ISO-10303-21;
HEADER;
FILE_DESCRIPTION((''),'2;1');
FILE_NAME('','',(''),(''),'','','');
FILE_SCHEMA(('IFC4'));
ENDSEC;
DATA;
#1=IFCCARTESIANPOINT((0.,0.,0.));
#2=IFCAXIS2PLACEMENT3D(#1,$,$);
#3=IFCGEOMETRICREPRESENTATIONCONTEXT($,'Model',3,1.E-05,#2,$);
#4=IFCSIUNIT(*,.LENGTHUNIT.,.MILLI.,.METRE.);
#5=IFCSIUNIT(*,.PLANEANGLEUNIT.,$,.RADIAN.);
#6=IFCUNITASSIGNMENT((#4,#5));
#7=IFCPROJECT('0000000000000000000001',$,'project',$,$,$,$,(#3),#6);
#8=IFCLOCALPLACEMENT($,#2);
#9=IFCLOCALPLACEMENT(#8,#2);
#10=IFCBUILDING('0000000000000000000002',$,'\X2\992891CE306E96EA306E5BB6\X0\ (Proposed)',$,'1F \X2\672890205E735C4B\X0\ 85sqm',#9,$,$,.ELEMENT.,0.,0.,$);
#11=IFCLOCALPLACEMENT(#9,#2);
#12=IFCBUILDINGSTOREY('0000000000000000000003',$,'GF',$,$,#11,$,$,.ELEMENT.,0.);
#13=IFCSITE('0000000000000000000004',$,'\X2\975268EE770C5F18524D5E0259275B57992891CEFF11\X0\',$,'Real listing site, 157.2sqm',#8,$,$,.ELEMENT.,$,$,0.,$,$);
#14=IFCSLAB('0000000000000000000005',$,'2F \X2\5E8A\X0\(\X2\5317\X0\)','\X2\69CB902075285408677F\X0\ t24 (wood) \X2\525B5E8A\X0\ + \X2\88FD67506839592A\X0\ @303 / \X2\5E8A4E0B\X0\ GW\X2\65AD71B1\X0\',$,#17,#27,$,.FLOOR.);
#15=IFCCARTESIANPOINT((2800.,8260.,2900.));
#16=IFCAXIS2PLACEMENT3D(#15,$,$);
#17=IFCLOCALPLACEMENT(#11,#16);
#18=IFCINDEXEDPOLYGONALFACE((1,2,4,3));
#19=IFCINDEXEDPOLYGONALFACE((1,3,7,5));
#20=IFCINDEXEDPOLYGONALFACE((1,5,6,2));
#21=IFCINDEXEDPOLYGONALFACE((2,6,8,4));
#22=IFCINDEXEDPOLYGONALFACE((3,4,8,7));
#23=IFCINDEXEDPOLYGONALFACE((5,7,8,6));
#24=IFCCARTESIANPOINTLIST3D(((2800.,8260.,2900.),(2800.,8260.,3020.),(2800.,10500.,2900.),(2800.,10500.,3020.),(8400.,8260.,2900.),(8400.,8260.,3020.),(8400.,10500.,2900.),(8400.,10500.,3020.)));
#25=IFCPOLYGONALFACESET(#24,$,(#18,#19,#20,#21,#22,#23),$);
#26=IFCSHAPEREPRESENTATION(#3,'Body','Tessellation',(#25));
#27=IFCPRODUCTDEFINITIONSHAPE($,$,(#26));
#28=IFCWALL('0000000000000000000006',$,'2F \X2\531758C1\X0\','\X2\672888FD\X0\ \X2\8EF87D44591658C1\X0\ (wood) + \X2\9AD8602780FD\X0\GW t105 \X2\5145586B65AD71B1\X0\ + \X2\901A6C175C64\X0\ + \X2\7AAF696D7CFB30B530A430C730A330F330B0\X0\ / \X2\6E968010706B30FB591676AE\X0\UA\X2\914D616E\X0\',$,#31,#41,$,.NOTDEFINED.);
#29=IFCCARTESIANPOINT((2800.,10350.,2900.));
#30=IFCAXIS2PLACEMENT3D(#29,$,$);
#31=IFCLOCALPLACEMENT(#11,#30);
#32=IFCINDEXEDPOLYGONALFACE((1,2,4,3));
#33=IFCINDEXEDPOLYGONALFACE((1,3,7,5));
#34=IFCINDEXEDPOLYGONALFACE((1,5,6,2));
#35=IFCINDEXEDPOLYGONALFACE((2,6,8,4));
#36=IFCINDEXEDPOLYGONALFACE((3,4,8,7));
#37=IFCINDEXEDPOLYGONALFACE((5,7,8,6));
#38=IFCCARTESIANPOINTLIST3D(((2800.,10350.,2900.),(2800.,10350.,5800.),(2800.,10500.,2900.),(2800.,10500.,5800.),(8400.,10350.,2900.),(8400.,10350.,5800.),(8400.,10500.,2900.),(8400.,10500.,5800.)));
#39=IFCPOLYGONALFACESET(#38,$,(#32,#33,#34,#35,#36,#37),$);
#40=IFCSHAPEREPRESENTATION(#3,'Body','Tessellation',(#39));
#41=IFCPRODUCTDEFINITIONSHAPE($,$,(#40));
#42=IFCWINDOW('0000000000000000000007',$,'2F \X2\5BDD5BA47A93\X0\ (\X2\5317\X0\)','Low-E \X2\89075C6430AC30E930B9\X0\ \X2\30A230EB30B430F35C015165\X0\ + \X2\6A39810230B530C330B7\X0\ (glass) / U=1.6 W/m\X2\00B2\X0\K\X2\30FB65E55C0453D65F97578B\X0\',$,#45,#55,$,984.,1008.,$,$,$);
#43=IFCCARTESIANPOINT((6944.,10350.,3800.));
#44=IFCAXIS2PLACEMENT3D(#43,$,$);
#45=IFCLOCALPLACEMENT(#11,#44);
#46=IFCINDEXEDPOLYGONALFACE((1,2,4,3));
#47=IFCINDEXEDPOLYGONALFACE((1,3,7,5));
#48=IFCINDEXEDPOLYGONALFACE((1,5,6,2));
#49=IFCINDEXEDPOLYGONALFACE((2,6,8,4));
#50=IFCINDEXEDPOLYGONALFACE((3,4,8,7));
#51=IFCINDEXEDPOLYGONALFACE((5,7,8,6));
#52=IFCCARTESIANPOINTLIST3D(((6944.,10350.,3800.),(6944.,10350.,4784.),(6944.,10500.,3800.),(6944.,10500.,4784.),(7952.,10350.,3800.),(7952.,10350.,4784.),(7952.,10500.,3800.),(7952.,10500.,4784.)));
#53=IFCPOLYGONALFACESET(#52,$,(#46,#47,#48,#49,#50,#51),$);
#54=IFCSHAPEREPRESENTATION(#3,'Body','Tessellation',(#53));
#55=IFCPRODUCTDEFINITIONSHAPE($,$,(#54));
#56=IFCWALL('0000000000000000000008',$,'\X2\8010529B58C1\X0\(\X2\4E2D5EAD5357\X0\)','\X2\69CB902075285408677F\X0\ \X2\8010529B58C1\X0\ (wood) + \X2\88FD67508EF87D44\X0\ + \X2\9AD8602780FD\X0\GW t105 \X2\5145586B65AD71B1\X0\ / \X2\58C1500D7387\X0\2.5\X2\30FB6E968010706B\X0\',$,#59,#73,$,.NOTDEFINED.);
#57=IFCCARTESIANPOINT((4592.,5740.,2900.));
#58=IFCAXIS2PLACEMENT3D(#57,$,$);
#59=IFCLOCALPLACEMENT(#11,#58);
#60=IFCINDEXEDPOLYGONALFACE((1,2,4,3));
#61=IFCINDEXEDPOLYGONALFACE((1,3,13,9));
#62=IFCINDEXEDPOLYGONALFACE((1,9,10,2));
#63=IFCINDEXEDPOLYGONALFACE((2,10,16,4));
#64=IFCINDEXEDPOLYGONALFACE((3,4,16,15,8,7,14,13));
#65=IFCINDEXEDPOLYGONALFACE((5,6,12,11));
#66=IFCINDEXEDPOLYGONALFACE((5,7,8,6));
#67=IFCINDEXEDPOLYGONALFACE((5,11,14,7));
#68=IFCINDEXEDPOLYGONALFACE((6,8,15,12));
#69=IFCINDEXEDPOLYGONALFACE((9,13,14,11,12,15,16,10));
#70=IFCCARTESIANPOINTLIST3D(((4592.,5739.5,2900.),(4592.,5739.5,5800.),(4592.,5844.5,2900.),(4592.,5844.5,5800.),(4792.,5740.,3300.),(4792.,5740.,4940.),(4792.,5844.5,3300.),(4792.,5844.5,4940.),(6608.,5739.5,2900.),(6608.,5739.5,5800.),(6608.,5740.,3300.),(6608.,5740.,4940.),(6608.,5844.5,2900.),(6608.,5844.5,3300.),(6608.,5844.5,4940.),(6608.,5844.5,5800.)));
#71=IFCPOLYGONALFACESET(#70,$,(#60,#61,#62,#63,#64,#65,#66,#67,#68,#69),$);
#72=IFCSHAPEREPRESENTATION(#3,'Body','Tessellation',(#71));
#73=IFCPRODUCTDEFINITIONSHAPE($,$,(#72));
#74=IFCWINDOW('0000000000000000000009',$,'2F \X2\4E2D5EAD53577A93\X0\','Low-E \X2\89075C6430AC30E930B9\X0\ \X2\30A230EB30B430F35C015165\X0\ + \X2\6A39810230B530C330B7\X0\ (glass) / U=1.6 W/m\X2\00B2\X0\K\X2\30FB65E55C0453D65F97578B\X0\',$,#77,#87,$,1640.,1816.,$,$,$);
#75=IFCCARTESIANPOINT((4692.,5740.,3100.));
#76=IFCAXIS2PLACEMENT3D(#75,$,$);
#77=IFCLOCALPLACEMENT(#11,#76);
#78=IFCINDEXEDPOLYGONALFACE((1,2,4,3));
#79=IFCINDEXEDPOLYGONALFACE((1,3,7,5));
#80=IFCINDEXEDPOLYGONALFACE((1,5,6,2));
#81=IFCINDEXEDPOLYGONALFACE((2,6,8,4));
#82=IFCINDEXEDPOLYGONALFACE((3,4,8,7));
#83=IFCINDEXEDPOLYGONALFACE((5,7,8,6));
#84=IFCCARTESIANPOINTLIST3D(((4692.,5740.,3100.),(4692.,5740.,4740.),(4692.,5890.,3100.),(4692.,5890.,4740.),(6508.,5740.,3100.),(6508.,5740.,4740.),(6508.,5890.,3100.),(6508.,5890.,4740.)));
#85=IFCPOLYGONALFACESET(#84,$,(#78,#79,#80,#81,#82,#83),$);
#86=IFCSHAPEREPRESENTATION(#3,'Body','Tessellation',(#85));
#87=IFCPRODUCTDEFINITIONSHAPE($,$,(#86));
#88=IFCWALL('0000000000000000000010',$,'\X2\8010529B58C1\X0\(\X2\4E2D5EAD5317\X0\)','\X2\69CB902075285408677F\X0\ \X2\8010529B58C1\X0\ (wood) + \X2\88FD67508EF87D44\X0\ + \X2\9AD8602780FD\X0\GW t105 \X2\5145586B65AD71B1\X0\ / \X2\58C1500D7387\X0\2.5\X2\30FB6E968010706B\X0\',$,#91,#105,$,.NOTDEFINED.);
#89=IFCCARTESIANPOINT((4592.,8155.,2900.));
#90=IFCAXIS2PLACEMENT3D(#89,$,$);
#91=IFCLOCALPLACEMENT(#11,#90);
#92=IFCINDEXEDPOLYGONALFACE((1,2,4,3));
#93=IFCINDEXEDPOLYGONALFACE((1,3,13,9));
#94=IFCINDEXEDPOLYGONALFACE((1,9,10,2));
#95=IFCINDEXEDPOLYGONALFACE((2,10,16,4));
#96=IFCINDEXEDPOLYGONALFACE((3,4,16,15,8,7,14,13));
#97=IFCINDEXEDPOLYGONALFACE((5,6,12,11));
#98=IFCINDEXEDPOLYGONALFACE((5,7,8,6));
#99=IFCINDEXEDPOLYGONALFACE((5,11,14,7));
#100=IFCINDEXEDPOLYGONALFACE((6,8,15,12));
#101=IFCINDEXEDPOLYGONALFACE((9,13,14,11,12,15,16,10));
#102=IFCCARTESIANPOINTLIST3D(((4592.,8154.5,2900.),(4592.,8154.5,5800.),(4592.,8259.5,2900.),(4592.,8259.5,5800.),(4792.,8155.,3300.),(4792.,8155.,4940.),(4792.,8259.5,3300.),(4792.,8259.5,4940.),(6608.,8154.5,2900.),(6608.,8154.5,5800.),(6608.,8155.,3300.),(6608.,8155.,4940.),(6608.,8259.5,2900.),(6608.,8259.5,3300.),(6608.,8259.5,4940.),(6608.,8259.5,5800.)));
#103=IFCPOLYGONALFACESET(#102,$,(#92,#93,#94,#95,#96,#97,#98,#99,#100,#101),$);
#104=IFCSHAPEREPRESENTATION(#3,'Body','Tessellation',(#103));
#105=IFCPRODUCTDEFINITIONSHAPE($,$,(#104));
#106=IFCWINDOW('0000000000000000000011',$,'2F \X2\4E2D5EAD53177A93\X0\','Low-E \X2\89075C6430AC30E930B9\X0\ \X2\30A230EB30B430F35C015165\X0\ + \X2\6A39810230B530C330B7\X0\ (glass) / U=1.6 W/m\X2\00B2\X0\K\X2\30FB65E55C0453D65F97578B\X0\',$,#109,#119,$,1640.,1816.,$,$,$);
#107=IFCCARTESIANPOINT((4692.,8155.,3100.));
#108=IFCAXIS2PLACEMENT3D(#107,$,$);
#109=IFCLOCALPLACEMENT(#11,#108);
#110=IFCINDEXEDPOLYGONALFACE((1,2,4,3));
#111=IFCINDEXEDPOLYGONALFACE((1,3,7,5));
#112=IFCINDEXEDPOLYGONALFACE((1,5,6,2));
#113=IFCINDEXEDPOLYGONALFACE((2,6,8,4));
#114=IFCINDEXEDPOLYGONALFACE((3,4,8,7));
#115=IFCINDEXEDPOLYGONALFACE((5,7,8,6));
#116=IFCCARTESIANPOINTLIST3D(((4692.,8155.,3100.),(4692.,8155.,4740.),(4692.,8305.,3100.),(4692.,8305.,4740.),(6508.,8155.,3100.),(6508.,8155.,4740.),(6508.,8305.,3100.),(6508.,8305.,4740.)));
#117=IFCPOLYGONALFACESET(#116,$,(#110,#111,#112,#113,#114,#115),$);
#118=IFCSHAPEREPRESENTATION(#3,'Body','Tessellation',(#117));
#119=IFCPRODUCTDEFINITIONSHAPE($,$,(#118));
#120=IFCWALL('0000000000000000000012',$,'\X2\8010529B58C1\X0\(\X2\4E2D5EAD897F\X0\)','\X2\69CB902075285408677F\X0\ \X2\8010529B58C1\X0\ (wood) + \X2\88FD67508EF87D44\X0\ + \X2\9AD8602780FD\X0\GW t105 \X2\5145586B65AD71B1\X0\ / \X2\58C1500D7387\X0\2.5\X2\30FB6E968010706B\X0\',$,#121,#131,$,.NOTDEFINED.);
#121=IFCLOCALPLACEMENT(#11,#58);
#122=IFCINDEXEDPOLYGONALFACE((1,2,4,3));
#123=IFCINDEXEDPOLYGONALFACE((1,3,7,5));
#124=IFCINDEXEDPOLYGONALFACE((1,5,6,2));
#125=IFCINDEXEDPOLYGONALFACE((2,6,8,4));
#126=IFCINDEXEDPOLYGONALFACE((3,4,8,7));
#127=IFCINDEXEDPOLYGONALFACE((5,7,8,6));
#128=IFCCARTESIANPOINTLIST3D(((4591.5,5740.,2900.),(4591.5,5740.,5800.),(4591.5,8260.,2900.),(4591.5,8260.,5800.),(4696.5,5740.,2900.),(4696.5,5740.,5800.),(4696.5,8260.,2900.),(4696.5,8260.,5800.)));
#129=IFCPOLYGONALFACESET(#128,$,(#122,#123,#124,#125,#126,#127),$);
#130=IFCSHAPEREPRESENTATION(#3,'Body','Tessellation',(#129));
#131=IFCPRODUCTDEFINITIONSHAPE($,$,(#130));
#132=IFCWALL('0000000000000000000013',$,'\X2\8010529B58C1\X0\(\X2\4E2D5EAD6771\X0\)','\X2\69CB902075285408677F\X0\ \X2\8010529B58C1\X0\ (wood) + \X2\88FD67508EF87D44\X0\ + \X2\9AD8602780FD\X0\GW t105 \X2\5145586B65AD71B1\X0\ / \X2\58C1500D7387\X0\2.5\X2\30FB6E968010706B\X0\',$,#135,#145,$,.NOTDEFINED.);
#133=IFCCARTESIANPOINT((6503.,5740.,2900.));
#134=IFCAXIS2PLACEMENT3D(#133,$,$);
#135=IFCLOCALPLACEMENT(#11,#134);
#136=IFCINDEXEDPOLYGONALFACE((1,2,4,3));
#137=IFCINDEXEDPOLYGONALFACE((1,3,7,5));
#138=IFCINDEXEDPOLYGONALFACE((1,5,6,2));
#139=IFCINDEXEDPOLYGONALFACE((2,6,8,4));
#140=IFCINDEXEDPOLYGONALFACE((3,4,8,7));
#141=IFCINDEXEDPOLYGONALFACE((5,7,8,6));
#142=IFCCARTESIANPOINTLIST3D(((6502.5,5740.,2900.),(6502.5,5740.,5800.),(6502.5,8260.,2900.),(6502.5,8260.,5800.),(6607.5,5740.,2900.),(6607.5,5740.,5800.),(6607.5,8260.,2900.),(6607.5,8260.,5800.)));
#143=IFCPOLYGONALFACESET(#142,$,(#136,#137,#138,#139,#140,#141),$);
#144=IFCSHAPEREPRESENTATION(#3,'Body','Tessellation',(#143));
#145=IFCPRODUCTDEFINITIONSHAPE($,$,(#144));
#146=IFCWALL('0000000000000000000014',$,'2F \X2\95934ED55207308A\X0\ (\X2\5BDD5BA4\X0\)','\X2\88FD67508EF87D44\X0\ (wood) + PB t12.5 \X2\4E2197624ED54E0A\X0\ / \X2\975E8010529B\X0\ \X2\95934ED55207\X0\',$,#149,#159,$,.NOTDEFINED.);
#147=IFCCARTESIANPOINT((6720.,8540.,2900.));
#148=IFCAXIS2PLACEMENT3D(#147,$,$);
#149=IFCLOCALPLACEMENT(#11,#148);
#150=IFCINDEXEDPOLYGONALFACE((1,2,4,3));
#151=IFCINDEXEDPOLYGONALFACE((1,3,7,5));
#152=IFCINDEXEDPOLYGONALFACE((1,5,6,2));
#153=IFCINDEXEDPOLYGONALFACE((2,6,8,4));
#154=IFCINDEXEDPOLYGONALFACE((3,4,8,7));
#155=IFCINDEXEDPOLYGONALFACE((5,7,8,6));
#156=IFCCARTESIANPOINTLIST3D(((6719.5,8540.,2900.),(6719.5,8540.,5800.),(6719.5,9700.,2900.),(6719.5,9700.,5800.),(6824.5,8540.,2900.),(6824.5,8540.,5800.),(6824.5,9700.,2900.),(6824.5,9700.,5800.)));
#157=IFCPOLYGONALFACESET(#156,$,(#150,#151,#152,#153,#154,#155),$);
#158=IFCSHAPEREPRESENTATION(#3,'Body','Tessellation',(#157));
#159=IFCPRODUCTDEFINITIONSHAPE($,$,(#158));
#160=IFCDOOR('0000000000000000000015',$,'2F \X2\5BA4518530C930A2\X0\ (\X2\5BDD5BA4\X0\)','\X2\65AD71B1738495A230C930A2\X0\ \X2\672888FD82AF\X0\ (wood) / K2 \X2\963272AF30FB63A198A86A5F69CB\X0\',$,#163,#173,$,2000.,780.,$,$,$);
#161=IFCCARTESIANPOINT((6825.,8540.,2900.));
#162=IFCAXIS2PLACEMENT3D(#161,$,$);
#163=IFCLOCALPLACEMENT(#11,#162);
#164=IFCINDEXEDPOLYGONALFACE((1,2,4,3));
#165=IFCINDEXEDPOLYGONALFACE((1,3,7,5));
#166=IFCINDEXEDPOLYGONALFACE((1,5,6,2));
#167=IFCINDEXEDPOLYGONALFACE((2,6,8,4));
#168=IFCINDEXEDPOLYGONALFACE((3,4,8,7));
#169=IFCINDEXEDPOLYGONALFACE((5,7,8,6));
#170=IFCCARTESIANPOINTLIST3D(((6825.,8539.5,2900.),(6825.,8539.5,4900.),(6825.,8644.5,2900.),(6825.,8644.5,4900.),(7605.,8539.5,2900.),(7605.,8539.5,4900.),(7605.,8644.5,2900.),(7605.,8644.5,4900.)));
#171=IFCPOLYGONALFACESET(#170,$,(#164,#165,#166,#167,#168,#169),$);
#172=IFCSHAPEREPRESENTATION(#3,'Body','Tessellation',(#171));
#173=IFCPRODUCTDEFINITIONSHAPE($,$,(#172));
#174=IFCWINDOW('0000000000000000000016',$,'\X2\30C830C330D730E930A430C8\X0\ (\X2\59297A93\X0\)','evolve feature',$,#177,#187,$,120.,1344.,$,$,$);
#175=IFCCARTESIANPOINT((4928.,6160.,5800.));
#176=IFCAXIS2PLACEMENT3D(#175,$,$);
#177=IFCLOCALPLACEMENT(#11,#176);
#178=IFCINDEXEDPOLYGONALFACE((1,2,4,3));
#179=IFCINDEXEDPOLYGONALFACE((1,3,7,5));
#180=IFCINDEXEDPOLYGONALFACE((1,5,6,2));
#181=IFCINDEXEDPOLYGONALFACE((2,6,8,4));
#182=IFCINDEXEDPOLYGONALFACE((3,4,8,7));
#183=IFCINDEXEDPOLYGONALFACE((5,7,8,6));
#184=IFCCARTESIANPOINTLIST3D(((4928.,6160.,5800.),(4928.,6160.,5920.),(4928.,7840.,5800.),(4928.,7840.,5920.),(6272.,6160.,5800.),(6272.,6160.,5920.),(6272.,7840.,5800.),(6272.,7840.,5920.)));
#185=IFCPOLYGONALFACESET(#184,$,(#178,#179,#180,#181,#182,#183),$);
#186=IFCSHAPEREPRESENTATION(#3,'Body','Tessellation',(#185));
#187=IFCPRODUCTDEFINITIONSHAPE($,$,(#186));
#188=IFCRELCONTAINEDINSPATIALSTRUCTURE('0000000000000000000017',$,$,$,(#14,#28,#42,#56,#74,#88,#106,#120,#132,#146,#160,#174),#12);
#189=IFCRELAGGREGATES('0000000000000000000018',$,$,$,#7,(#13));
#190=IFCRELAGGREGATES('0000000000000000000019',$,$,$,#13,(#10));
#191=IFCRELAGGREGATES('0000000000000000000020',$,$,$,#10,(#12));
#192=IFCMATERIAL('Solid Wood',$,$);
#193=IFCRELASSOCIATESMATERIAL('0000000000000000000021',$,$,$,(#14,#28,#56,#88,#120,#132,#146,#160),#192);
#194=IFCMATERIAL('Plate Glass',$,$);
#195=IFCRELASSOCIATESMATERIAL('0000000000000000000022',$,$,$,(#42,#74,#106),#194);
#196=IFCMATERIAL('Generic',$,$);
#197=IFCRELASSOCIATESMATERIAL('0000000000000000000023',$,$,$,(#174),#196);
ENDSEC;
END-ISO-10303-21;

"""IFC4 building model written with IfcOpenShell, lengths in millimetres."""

from ifc_helpers import new_model, si_unit, frame, frame_2d, origin, place, context, project, spatial, rectangle, extrude, material, element, fill, save


model = new_model("IFC4")

# Units and contexts
model_context = context("Model", 3, precision=1e-05, world=origin())
ifc_project = project(units=[si_unit("LENGTHUNIT", "METRE", prefix="MILLI"), si_unit("PLANEANGLEUNIT", "RADIAN")], contexts=[model_context])

# Site, building, storey
site_placement = place(None, origin())
site = spatial("IfcSite", under=ifc_project, at=site_placement, Name="青森県弘前市大字館野１", ObjectType="Real listing site, 157.2sqm", CompositionType="ELEMENT", RefElevation=0.0)
building_placement = place(site_placement, origin())
building = spatial("IfcBuilding", under=site, at=building_placement, Name="館野の雪の家 (Proposed)", ObjectType="1F 木造平屋 85sqm", CompositionType="ELEMENT", ElevationOfRefHeight=0.0, ElevationOfTerrain=0.0)
storey_placement = place(building_placement, origin())
storey = spatial("IfcBuildingStorey", under=building, at=storey_placement, Name="GF", CompositionType="ELEMENT", Elevation=0.0)

# Slab
ifc_material_1 = material(Name="Solid Wood")
slab_placement = place(storey_placement, frame((2800.0, 8260.0, 2900.0)))
element("IfcSlab", 1, at=slab_placement, inside=storey, material=ifc_material_1, Name="2F 床(北)", Description="構造用合板 t24 (wood) 剛床 + 製材根太 @303 / 床下 GW断熱", PredefinedType="FLOOR", context=model_context, shape_type="SweptSolid", body=[
    extrude(rectangle(XDim=5600.0, YDim=2240.0, at=frame_2d((2800.0, 1120.0))), frame((2800.0, 8260.0, 2900.0)), (0.0, 0.0, 1.0), 120.0),
])

# Walls, openings, windows
wall_1_placement = place(storey_placement, frame((2800.0, 10350.0, 2900.0)))
wall_1 = element("IfcWall", 2, at=wall_1_placement, inside=storey, material=ifc_material_1, Name="2F 北壁", Description="木製 軸組外壁 (wood) + 高性能GW t105 充填断熱 + 通気層 + 窯業系サイディング / 準耐火・外皮UA配慮", PredefinedType="NOTDEFINED", context=model_context, shape_type="SweptSolid", body=[
    extrude(rectangle(XDim=5600.0, YDim=150.0, at=frame_2d((2800.0, 75.0))), frame((2800.0, 10350.0, 2900.0)), (0.0, 0.0, 1.0), 2900.0),
])
opening_1_placement = place(storey_placement, frame((6944.0, 10350.0, 3800.0)))
opening_1 = element("IfcOpeningElement", 3, at=opening_1_placement, cuts=wall_1, PredefinedType="NOTDEFINED", context=model_context, shape_type="SweptSolid", body=[
    extrude(rectangle(XDim=1008.0, YDim=150.0, at=frame_2d((504.0, 75.0))), frame((6944.0, 10350.0, 3800.0)), (0.0, 0.0, 1.0), 984.0),
])
ifc_material_2 = material(Name="Plate Glass")
window_1_placement = place(storey_placement, frame((6944.0, 10350.0, 3800.0)))
window_1 = element("IfcWindow", 4, at=window_1_placement, inside=storey, material=ifc_material_2, Name="2F 寝室窓 (北)", Description="Low-E 複層ガラス アルゴン封入 + 樹脂サッシ (glass) / U=1.6 W/m²K・日射取得型", OverallHeight=984.0, OverallWidth=1008.0, context=model_context, shape_type="SweptSolid", body=[
    extrude(rectangle(XDim=1008.0, YDim=150.0, at=frame_2d((504.0, 75.0))), frame((6944.0, 10350.0, 3800.0)), (0.0, 0.0, 1.0), 984.0),
])
fill(opening_1, window_1)
wall_2_placement = place(storey_placement, frame((4592.0, 5740.0, 2900.0)))
wall_2 = element("IfcWall", 5, at=wall_2_placement, inside=storey, material=ifc_material_1, Name="耐力壁(中庭南)", Description="構造用合板 耐力壁 (wood) + 製材軸組 + 高性能GW t105 充填断熱 / 壁倍率2.5・準耐火", PredefinedType="NOTDEFINED", context=model_context, shape_type="SweptSolid", body=[
    extrude(rectangle(XDim=2016.0, YDim=105.0, at=frame_2d((1008.0, 52.0))), frame((4592.0, 5740.0, 2900.0)), (0.0, 0.0, 1.0), 2900.0),
])
opening_2_placement = place(storey_placement, frame((4692.0, 5740.0, 3100.0)))
opening_2 = element("IfcOpeningElement", 6, at=opening_2_placement, cuts=wall_2, PredefinedType="NOTDEFINED", context=model_context, shape_type="SweptSolid", body=[
    extrude(rectangle(XDim=1816.0, YDim=150.0, at=frame_2d((908.0, 75.0))), frame((4692.0, 5740.0, 3100.0)), (0.0, 0.0, 1.0), 1640.0),
])
window_2_placement = place(storey_placement, frame((4692.0, 5740.0, 3100.0)))
window_2 = element("IfcWindow", 7, at=window_2_placement, inside=storey, material=ifc_material_2, Name="2F 中庭南窓", Description="Low-E 複層ガラス アルゴン封入 + 樹脂サッシ (glass) / U=1.6 W/m²K・日射取得型", OverallHeight=1640.0, OverallWidth=1816.0, context=model_context, shape_type="SweptSolid", body=[
    extrude(rectangle(XDim=1816.0, YDim=150.0, at=frame_2d((908.0, 75.0))), frame((4692.0, 5740.0, 3100.0)), (0.0, 0.0, 1.0), 1640.0),
])
fill(opening_2, window_2)
wall_3_placement = place(storey_placement, frame((4592.0, 8155.0, 2900.0)))
wall_3 = element("IfcWall", 8, at=wall_3_placement, inside=storey, material=ifc_material_1, Name="耐力壁(中庭北)", Description="構造用合板 耐力壁 (wood) + 製材軸組 + 高性能GW t105 充填断熱 / 壁倍率2.5・準耐火", PredefinedType="NOTDEFINED", context=model_context, shape_type="SweptSolid", body=[
    extrude(rectangle(XDim=2016.0, YDim=105.0, at=frame_2d((1008.0, 52.0))), frame((4592.0, 8155.0, 2900.0)), (0.0, 0.0, 1.0), 2900.0),
])
opening_3_placement = place(storey_placement, frame((4692.0, 8155.0, 3100.0)))
opening_3 = element("IfcOpeningElement", 9, at=opening_3_placement, cuts=wall_3, PredefinedType="NOTDEFINED", context=model_context, shape_type="SweptSolid", body=[
    extrude(rectangle(XDim=1816.0, YDim=150.0, at=frame_2d((908.0, 75.0))), frame((4692.0, 8155.0, 3100.0)), (0.0, 0.0, 1.0), 1640.0),
])
window_3_placement = place(storey_placement, frame((4692.0, 8155.0, 3100.0)))
window_3 = element("IfcWindow", 10, at=window_3_placement, inside=storey, material=ifc_material_2, Name="2F 中庭北窓", Description="Low-E 複層ガラス アルゴン封入 + 樹脂サッシ (glass) / U=1.6 W/m²K・日射取得型", OverallHeight=1640.0, OverallWidth=1816.0, context=model_context, shape_type="SweptSolid", body=[
    extrude(rectangle(XDim=1816.0, YDim=150.0, at=frame_2d((908.0, 75.0))), frame((4692.0, 8155.0, 3100.0)), (0.0, 0.0, 1.0), 1640.0),
])
fill(opening_3, window_3)

# Walls
wall_4_placement = place(storey_placement, frame((4592.0, 5740.0, 2900.0)))
element("IfcWall", 11, at=wall_4_placement, inside=storey, material=ifc_material_1, Name="耐力壁(中庭西)", Description="構造用合板 耐力壁 (wood) + 製材軸組 + 高性能GW t105 充填断熱 / 壁倍率2.5・準耐火", PredefinedType="NOTDEFINED", context=model_context, shape_type="SweptSolid", body=[
    extrude(rectangle(XDim=105.0, YDim=2520.0, at=frame_2d((52.0, 1260.0))), frame((4592.0, 5740.0, 2900.0)), (0.0, 0.0, 1.0), 2900.0),
])
wall_5_placement = place(storey_placement, frame((6503.0, 5740.0, 2900.0)))
element("IfcWall", 12, at=wall_5_placement, inside=storey, material=ifc_material_1, Name="耐力壁(中庭東)", Description="構造用合板 耐力壁 (wood) + 製材軸組 + 高性能GW t105 充填断熱 / 壁倍率2.5・準耐火", PredefinedType="NOTDEFINED", context=model_context, shape_type="SweptSolid", body=[
    extrude(rectangle(XDim=105.0, YDim=2520.0, at=frame_2d((52.0, 1260.0))), frame((6503.0, 5740.0, 2900.0)), (0.0, 0.0, 1.0), 2900.0),
])
wall_6_placement = place(storey_placement, frame((6720.0, 8540.0, 2900.0)))
element("IfcWall", 13, at=wall_6_placement, inside=storey, material=ifc_material_1, Name="2F 間仕切り (寝室)", Description="製材軸組 (wood) + PB t12.5 両面仕上 / 非耐力 間仕切", PredefinedType="NOTDEFINED", context=model_context, shape_type="SweptSolid", body=[
    extrude(rectangle(XDim=105.0, YDim=1160.0, at=frame_2d((52.0, 580.0))), frame((6720.0, 8540.0, 2900.0)), (0.0, 0.0, 1.0), 2900.0),
])

# Door
door_placement = place(storey_placement, frame((6825.0, 8540.0, 2900.0)))
element("IfcDoor", 14, at=door_placement, inside=storey, material=ifc_material_1, Name="2F 室内ドア (寝室)", Description="断熱玄関ドア 木製芯 (wood) / K2 防犯・採風機構", OverallHeight=2000.0, OverallWidth=780.0, context=model_context, shape_type="SweptSolid", body=[
    extrude(rectangle(XDim=780.0, YDim=105.0, at=frame_2d((390.0, 52.0))), frame((6825.0, 8540.0, 2900.0)), (0.0, 0.0, 1.0), 2000.0),
])

# Window
ifc_material_3 = material(Name="Generic")
window_4_placement = place(storey_placement, frame((4928.0, 6160.0, 5800.0)))
element("IfcWindow", 15, at=window_4_placement, inside=storey, material=ifc_material_3, Name="トップライト (天窓)", Description="evolve feature", OverallHeight=120.0, OverallWidth=1344.0, context=model_context, shape_type="SweptSolid", body=[
    extrude(rectangle(XDim=1344.0, YDim=1680.0, at=frame_2d((672.0, 840.0))), frame((4928.0, 6160.0, 5800.0)), (0.0, 0.0, 1.0), 120.0),
])

save(model, "model.ifc")
